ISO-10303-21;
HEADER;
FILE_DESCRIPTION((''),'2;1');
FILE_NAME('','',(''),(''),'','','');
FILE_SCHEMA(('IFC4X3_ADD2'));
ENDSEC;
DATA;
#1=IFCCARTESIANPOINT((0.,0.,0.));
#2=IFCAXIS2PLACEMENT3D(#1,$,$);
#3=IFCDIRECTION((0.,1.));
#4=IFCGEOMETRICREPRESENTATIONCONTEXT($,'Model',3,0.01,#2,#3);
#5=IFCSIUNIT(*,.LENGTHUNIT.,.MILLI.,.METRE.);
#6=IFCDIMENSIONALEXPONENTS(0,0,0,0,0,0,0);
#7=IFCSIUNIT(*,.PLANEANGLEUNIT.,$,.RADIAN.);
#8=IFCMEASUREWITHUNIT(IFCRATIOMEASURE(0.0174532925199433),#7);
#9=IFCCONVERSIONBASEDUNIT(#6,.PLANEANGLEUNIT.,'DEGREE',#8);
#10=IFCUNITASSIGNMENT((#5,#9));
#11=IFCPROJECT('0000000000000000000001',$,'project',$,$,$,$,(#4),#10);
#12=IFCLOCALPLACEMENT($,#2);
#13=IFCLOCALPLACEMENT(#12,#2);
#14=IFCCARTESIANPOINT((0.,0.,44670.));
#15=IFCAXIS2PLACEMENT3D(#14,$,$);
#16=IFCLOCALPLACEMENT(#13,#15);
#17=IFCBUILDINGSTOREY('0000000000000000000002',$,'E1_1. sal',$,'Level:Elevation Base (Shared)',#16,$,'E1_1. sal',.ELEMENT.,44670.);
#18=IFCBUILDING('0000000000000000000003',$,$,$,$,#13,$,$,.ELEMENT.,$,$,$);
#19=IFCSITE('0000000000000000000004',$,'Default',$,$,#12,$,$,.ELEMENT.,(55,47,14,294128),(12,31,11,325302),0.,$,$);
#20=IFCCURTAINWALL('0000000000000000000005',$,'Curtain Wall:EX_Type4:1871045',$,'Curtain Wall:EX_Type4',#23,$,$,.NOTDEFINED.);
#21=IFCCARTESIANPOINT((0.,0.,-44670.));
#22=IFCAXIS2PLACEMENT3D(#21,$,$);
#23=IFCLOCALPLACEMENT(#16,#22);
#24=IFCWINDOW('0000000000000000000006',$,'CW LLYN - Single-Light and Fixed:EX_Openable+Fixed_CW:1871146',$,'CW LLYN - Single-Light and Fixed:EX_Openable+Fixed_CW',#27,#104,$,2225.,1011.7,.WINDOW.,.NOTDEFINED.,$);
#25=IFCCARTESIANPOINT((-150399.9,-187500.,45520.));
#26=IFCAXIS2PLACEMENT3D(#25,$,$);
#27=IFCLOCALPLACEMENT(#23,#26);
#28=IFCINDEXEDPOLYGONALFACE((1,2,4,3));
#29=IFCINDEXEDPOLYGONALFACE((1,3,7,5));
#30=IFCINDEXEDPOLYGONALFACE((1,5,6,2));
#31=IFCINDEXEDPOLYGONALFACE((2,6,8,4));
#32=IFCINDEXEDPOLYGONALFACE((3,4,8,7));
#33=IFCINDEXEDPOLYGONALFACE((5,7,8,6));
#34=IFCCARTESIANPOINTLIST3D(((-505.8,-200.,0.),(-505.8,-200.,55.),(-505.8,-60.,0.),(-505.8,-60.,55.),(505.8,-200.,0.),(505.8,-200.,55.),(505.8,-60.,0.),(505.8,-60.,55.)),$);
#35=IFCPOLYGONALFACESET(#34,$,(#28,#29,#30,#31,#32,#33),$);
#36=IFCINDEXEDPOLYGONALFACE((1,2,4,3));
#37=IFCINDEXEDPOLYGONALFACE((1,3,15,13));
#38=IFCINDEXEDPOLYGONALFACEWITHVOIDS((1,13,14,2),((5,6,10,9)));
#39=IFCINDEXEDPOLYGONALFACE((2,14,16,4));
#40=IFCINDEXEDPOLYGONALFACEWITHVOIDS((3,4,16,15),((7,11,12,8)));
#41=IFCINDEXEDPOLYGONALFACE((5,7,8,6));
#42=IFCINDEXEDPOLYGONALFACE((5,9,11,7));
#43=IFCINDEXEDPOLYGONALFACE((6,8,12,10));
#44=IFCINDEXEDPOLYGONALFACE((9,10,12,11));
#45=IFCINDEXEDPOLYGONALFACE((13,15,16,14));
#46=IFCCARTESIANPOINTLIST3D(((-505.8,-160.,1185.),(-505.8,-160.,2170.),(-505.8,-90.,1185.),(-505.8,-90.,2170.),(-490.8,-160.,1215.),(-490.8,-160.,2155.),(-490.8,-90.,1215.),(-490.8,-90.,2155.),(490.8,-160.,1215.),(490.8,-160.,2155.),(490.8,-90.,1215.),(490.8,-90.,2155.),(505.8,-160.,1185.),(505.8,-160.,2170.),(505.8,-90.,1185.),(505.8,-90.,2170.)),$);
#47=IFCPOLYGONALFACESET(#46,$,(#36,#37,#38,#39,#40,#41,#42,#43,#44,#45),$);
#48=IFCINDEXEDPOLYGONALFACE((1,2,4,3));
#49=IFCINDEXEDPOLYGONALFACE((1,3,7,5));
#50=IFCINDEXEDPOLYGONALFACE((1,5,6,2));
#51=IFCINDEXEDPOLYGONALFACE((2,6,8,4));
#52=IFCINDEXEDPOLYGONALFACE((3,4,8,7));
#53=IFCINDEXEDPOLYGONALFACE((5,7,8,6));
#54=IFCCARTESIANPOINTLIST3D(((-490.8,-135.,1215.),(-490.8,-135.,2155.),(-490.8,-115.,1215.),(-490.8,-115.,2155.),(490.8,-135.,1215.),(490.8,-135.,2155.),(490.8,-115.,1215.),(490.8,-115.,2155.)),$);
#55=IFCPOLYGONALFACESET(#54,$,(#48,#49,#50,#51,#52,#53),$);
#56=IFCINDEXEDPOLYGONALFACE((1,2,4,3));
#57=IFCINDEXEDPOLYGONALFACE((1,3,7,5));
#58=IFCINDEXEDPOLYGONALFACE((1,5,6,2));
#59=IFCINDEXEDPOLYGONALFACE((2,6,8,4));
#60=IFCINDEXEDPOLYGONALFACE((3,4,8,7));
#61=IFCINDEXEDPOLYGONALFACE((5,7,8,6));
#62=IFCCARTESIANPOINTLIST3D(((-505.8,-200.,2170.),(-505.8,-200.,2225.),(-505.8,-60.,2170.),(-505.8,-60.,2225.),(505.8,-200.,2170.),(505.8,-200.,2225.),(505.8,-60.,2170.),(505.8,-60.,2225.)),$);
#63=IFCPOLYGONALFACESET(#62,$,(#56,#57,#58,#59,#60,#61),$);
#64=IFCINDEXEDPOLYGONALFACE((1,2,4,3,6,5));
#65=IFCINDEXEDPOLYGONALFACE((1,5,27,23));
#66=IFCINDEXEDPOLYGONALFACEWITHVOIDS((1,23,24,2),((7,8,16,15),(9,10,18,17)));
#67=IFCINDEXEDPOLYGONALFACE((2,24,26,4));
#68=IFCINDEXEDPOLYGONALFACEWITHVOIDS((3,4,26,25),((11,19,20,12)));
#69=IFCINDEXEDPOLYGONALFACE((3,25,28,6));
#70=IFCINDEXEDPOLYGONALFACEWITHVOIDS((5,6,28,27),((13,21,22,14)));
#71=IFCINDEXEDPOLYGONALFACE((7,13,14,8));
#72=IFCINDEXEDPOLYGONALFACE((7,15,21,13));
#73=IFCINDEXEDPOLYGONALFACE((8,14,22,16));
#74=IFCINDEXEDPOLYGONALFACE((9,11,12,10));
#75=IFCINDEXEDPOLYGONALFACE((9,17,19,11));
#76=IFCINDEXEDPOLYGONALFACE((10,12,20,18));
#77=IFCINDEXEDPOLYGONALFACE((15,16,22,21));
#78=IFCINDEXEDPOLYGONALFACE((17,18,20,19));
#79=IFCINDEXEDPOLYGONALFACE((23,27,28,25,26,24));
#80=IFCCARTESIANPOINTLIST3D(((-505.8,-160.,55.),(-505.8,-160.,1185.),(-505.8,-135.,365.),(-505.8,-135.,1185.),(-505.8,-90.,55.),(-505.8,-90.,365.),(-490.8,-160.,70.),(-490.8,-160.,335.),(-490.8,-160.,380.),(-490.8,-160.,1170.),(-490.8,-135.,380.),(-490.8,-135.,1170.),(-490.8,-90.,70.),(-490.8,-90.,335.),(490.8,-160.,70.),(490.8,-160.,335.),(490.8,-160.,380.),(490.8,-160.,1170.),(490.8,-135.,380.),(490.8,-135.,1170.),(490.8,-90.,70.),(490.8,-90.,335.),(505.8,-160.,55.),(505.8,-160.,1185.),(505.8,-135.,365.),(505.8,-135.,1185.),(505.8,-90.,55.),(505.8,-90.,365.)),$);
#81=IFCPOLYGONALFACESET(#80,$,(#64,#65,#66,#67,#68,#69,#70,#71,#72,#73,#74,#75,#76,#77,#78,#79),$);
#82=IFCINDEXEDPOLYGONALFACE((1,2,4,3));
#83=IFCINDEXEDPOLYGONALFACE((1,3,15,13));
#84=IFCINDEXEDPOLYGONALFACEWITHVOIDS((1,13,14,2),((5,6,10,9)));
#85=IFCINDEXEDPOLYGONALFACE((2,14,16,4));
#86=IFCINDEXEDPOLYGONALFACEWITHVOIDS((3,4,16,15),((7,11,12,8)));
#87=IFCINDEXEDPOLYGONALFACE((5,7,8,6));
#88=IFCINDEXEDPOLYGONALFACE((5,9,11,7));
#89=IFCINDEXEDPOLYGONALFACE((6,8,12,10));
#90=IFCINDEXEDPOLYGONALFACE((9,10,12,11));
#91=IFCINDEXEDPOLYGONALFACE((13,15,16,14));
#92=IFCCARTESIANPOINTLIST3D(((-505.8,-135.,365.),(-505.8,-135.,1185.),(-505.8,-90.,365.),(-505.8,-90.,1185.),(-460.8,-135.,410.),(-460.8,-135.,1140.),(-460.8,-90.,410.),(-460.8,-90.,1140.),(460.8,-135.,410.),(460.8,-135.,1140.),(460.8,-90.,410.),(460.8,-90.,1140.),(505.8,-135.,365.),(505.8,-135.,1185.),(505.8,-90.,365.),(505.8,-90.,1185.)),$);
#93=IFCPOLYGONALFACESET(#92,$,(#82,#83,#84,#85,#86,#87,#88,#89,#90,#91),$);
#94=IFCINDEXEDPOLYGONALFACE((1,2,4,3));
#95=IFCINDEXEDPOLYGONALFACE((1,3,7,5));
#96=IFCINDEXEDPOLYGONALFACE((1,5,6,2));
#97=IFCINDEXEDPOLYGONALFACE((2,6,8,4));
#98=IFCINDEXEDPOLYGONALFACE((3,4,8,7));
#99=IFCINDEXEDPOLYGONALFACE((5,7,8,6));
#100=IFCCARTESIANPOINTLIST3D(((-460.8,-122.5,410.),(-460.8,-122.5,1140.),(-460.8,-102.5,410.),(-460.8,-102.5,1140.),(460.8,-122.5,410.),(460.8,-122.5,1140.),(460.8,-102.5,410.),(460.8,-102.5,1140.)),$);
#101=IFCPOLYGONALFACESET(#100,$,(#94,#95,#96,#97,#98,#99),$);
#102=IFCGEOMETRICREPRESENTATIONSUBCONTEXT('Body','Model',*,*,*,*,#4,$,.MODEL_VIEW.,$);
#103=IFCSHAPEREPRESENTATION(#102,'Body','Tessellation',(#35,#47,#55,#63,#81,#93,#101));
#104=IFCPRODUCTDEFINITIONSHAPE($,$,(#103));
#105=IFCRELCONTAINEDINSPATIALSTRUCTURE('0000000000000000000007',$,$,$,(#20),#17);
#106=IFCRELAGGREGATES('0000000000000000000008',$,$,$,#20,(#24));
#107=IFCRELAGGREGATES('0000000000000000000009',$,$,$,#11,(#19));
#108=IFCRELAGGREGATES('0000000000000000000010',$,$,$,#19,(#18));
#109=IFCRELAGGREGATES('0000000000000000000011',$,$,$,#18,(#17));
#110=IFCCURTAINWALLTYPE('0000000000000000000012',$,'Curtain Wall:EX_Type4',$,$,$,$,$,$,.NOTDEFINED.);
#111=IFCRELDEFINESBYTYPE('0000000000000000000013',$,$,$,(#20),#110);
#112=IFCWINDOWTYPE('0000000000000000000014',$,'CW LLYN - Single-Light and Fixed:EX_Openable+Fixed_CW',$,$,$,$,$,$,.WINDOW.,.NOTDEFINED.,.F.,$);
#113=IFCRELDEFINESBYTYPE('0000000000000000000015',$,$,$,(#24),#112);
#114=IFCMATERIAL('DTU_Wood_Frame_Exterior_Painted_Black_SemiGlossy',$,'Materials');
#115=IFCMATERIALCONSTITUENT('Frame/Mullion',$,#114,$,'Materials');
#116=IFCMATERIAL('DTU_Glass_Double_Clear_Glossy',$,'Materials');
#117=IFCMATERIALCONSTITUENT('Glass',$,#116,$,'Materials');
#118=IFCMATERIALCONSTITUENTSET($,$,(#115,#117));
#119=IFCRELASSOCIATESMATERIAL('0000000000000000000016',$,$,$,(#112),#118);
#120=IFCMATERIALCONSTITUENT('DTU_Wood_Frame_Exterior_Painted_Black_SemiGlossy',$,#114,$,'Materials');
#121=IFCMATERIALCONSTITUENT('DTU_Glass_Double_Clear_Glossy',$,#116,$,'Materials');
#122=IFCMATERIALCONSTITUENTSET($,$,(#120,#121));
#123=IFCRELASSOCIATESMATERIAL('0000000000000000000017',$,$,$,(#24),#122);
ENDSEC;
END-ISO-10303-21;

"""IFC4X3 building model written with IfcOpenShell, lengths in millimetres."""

from ifc_helpers import new_model, entity, si_unit, converted_unit, direction, frame, frame_2d, origin, origin_2d_with_axis, place, context, subcontext, project, spatial, polyline, rectangle, outline, extrude, source, transform, mapped, material, constituent, constituent_set, type_object, type_shapes, element, aggregate, save


model = new_model("IFC4X3")

# Units and contexts
model_context = context("Model", 3, precision=0.01, world=origin(), true_north=direction((0.0, 1.0)))
body_context = subcontext(model_context, "Body", "Model", "MODEL_VIEW")
ifc_project = project(units=[si_unit("LENGTHUNIT", "METRE", prefix="MILLI"), converted_unit("PLANEANGLEUNIT", "DEGREE", entity("IfcRatioMeasure", 0.0174532925199433), si_unit("PLANEANGLEUNIT", "RADIAN"), dimensions=[0, 0, 0, 0, 0, 0, 0])], contexts=[model_context])

# Site, building, storey
site_placement = place(None, origin())
site = spatial("IfcSite", under=ifc_project, at=site_placement, Name="Default", CompositionType="ELEMENT", RefLatitude=(55, 47, 14, 294128), RefLongitude=(12, 31, 11, 325302), RefElevation=0.0)
building_placement = place(site_placement, origin())
building = spatial("IfcBuilding", under=site, at=building_placement, CompositionType="ELEMENT")
storey_placement = place(building_placement, frame((0.0, 0.0, 44670.0)))
storey = spatial("IfcBuildingStorey", under=building, at=storey_placement, Name="E1_1. sal", ObjectType="Level:Elevation Base (Shared)", LongName="E1_1. sal", CompositionType="ELEMENT", Elevation=44670.0)

# Curtain wall, window, openings
curtain_wall_type = type_object("IfcCurtainWallType", Name="Curtain Wall:EX_Type4", PredefinedType="NOTDEFINED")
curtain_wall_placement = place(storey_placement, frame((0.0, 0.0, -44670.0)))
curtain_wall = element("IfcCurtainWall", 1, at=curtain_wall_placement, inside=storey, type_object=curtain_wall_type, Name="Curtain Wall:EX_Type4:1871045", ObjectType="Curtain Wall:EX_Type4", PredefinedType="NOTDEFINED")
ifc_material_1 = material(Name="DTU_Wood_Frame_Exterior_Painted_Black_SemiGlossy", Category="Materials")
ifc_material_2 = material(Name="DTU_Glass_Double_Clear_Glossy", Category="Materials")
ifc_constituent_1 = constituent(ifc_material_1, Name="DTU_Wood_Frame_Exterior_Painted_Black_SemiGlossy", Category="Materials")
ifc_constituent_2 = constituent(ifc_material_2, Name="DTU_Glass_Double_Clear_Glossy", Category="Materials")
ifc_constituent_set_1 = constituent_set(constituents=[ifc_constituent_1, ifc_constituent_2])
ifc_constituent_3 = constituent(ifc_material_1, Name="Frame/Mullion", Category="Materials")
ifc_constituent_4 = constituent(ifc_material_2, Name="Glass", Category="Materials")
ifc_constituent_set_2 = constituent_set(constituents=[ifc_constituent_3, ifc_constituent_4])
window_type_1 = type_object("IfcWindowType", Name="CW LLYN - Single-Light and Fixed:EX_Openable+Fixed_CW", ParameterTakesPrecedence=False, PartitioningType="NOTDEFINED", PredefinedType="WINDOW", material=ifc_constituent_set_2)
shared_shape_1 = source(origin(), body_context, "Body", "SweptSolid", [
    extrude(rectangle(XDim=140.0, YDim=1011.7, at=origin_2d_with_axis()), frame((0.0, -130.0, 0.0), z_axis=(0.0, 0.0, 1.0), x_axis=(0.0, -1.0, 0.0)), (0.0, 0.0, 1.0), 55.0),
    extrude(outline(polyline([(-492.5, -505.8), (492.5, -505.8), (492.5, 505.8), (-492.5, 505.8), (-492.5, -505.8)]), holes=[polyline([(477.5, -490.8), (-462.5, -490.8), (-462.5, 490.8), (477.5, 490.8), (477.5, -490.8)])]), frame((0.0, -90.0, 1677.5), z_axis=(0.0, -1.0, 0.0), x_axis=(0.0, 0.0, 1.0)), (0.0, 0.0, 1.0), 70.0),
    extrude(rectangle(XDim=981.7, YDim=20.0, at=frame_2d((0.0, 0.0), x_axis=(1.0, 0.0))), frame((0.0, -125.0, 1215.0), z_axis=(0.0, 0.0, 1.0), x_axis=(-1.0, 0.0, 0.0)), (0.0, 0.0, 1.0), 940.0),
    extrude(rectangle(XDim=981.7, YDim=20.0, at=frame_2d((0.0, 0.0), x_axis=(1.0, 0.0))), frame((0.0, -125.0, 70.0), z_axis=(0.0, 0.0, 1.0), x_axis=(-1.0, 0.0, 0.0)), (0.0, 0.0, 1.0), 265.0),
    extrude(rectangle(XDim=140.0, YDim=1011.7, at=frame_2d((0.0, 0.0), x_axis=(1.0, 0.0))), frame((0.0, -130.0, 2170.0), z_axis=(0.0, 0.0, 1.0), x_axis=(0.0, -1.0, 0.0)), (0.0, 0.0, 1.0), 55.0),
    extrude(outline(polyline([(-38.3, -480.0), (31.7, -480.0), (31.7, 650.0), (6.7, 650.0), (6.7, -170.0), (-38.3, -170.0), (-38.3, -480.0)])), frame((505.8, -128.3, 535.0), z_axis=(-1.0, 0.0, 0.0), x_axis=(0.0, -1.0, 0.0)), (0.0, 0.0, 1.0), 1011.7),
    extrude(outline(polyline([(-410.0, -505.8), (410.0, -505.8), (410.0, 505.8), (-410.0, 505.8), (-410.0, -505.8)]), holes=[polyline([(-365.0, 460.8), (365.0, 460.8), (365.0, -460.8), (-365.0, -460.8), (-365.0, 460.8)])]), frame((0.0, -90.0, 775.0), z_axis=(0.0, -1.0, 0.0), x_axis=(0.0, 0.0, 1.0)), (0.0, 0.0, 1.0), 45.0),
    extrude(rectangle(XDim=921.7, YDim=20.0, at=frame_2d((0.0, 0.0), x_axis=(1.0, 0.0))), frame((0.0, -112.5, 410.0), z_axis=(0.0, 0.0, 1.0), x_axis=(-1.0, 0.0, 0.0)), (0.0, 0.0, 1.0), 730.0),
])
type_shapes(window_type_1, [shared_shape_1])
window_1_placement = place(curtain_wall_placement, frame((-150399.9, -187500.0, 45520.0)))
window_1 = element("IfcWindow", 2, at=window_1_placement, type_object=window_type_1, material=ifc_constituent_set_1, Name="CW LLYN - Single-Light and Fixed:EX_Openable+Fixed_CW:1871146", ObjectType="CW LLYN - Single-Light and Fixed:EX_Openable+Fixed_CW", OverallHeight=2225.0, OverallWidth=1011.7, PartitioningType="NOTDEFINED", PredefinedType="WINDOW", context=body_context, shape_type="MappedRepresentation", body=[
    mapped(shared_shape_1, transform((0.0, 0.0, 0.0), scale=1.0)),
])
opening_1_placement = place(curtain_wall_placement, frame((-150399.9, -187500.0, 90190.0), z_axis=(0.0, 0.0, 1.0), x_axis=(-1.0, 0.0, 0.0)))
opening_1 = element("IfcOpeningElement", 3, at=opening_1_placement, cuts=window_1, PredefinedType="OPENING", context=body_context, shape_type="SweptSolid", body=[
    extrude(rectangle(XDim=265.0, YDim=981.7, at=frame_2d((0.0, 0.0), x_axis=(1.0, 0.0))), frame((0.0, 160.0, -44467.5), z_axis=(0.0, -1.0, 0.0), x_axis=(0.0, 0.0, 1.0)), (0.0, 0.0, 1.0), 70.0),
])
opening_2_placement = place(curtain_wall_placement, frame((-150399.9, -187500.0, 90190.0), z_axis=(0.0, 0.0, 1.0), x_axis=(-1.0, 0.0, 0.0)))
opening_2 = element("IfcOpeningElement", 4, at=opening_2_placement, cuts=window_1, PredefinedType="OPENING", context=body_context, shape_type="SweptSolid", body=[
    extrude(rectangle(XDim=790.0, YDim=981.7, at=frame_2d((0.0, 0.0), x_axis=(1.0, 0.0))), frame((0.0, 135.0, -43895.0), z_axis=(0.0, 1.0, 0.0), x_axis=(0.0, 0.0, 1.0)), (0.0, 0.0, 1.0), 25.0),
])
aggregate(curtain_wall, [window_1, opening_1, opening_2])

save(model, "model.ifc")
